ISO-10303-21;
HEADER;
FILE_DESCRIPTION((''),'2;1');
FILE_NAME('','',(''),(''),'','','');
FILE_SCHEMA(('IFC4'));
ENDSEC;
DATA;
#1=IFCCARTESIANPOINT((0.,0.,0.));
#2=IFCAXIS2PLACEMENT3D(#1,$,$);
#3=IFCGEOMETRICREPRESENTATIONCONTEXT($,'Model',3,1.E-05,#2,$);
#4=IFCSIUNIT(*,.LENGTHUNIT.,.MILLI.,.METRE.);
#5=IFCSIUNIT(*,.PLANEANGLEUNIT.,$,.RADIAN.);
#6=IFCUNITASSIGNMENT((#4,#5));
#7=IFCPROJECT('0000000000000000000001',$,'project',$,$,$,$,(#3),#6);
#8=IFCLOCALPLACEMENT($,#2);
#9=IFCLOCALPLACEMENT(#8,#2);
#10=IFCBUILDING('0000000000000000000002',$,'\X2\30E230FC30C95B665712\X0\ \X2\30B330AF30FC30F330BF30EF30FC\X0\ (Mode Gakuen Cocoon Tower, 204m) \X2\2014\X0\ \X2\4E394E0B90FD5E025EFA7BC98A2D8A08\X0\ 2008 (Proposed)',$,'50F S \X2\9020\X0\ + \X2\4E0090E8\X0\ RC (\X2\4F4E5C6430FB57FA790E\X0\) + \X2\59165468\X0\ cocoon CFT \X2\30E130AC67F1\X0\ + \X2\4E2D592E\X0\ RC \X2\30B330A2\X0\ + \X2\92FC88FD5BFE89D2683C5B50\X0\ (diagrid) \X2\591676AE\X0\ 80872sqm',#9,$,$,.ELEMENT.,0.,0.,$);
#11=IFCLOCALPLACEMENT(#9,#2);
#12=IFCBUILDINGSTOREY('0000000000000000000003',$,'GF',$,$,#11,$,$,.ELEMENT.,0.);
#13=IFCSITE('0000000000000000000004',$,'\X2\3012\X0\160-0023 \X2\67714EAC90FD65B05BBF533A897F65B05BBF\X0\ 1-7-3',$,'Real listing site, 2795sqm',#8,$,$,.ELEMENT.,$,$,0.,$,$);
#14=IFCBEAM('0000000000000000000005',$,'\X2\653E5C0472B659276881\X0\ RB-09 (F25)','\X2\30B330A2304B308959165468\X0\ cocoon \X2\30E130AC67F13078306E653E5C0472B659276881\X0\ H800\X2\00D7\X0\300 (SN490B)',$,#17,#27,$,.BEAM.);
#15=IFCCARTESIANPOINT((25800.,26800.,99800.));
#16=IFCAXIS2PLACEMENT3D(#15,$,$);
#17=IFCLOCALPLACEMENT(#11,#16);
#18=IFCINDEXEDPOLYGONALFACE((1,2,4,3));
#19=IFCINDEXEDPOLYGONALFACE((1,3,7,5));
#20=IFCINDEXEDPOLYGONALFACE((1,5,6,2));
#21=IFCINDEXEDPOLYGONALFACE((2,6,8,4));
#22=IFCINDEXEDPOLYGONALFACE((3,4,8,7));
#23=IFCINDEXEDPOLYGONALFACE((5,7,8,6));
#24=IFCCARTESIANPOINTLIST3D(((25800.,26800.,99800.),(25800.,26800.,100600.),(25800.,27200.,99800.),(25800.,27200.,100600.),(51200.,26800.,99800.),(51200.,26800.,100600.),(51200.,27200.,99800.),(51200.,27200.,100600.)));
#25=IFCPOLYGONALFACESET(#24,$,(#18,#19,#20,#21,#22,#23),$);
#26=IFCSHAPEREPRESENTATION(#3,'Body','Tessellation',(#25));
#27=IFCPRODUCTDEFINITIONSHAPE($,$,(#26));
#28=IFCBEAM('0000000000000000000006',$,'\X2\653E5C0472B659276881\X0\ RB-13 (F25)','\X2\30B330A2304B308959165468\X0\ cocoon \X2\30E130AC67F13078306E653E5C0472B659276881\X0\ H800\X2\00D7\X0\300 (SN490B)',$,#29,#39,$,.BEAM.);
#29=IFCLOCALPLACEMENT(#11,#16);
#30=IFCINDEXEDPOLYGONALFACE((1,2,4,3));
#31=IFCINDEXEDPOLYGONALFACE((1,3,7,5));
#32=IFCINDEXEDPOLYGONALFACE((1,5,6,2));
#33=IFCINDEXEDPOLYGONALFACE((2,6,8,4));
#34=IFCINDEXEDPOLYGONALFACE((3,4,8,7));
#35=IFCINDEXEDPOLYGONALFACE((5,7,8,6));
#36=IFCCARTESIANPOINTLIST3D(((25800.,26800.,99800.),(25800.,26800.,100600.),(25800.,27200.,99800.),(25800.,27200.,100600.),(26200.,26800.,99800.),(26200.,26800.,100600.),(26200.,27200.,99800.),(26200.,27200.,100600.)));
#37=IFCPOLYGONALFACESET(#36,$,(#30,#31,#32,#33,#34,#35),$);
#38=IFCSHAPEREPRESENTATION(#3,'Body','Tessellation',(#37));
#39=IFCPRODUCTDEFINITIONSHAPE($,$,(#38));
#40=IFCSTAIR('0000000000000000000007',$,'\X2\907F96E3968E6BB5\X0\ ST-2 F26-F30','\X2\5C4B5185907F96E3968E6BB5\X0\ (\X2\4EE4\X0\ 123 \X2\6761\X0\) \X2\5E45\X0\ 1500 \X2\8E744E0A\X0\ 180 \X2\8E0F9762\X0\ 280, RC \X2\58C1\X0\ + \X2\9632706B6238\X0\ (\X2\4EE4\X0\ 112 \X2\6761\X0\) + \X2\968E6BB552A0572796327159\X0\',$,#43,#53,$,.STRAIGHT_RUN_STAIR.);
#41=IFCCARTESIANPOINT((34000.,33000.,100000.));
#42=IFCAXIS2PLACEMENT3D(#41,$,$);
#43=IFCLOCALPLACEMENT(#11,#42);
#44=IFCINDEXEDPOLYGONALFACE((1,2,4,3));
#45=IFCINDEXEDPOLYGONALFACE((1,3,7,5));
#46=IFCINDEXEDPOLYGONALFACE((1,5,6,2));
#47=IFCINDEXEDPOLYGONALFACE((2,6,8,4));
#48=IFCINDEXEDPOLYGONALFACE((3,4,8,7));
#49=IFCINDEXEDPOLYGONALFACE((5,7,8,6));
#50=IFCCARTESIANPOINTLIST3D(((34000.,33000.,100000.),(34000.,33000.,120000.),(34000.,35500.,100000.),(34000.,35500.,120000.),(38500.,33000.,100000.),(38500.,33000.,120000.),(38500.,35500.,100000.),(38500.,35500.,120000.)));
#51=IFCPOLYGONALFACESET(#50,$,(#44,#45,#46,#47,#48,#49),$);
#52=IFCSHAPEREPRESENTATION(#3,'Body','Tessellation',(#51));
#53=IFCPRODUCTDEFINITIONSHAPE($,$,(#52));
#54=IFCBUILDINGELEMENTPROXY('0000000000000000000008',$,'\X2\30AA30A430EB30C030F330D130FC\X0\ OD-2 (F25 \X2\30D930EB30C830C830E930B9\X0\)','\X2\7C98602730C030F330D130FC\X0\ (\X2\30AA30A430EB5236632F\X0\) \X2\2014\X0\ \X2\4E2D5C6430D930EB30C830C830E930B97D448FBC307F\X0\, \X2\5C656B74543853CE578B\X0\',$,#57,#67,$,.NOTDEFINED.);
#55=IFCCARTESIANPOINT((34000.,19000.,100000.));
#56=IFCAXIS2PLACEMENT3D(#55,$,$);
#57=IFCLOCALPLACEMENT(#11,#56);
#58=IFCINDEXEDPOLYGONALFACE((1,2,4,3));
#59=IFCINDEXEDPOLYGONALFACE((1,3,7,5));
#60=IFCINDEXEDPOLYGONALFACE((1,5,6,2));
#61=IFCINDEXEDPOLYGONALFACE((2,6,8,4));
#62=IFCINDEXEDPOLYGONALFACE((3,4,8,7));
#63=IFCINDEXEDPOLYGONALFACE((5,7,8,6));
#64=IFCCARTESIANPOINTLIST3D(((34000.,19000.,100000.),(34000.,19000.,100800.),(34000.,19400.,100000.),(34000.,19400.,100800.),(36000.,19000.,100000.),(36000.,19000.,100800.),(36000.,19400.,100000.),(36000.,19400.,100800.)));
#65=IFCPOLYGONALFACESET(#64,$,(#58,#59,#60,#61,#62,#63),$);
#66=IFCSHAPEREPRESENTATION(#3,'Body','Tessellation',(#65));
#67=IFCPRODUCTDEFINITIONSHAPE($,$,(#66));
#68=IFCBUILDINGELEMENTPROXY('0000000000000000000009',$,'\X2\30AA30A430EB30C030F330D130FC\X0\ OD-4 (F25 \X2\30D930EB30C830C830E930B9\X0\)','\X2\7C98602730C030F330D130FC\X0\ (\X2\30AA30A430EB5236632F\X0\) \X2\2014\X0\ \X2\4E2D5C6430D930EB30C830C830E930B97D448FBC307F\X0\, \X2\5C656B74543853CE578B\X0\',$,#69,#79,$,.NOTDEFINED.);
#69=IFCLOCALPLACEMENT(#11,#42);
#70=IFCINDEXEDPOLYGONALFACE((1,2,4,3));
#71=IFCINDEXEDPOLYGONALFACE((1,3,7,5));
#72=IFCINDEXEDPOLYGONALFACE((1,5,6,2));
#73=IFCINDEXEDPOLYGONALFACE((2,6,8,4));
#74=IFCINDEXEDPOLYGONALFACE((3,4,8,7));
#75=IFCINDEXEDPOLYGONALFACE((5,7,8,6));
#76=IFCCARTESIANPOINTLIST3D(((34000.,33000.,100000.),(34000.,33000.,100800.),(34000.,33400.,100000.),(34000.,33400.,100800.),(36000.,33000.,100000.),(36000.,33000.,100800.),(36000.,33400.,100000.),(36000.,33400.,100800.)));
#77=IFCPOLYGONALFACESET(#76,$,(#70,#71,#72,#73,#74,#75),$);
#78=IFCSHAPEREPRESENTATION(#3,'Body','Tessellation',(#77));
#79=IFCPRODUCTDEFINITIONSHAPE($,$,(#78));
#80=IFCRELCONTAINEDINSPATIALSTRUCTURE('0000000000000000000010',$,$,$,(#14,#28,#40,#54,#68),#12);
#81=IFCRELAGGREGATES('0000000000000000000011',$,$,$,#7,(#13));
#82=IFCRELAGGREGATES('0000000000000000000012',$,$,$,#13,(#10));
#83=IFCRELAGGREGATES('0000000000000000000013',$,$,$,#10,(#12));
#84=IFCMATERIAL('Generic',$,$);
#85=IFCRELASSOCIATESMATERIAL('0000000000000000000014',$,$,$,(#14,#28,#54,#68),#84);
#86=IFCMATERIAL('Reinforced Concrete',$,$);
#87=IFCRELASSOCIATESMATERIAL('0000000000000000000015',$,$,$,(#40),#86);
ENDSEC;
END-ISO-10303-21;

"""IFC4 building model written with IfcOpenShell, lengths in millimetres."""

from ifc_helpers import new_model, si_unit, frame, frame_2d, origin, place, context, project, spatial, rectangle, extrude, material, element, save


model = new_model("IFC4")

# Units and contexts
model_context = context("Model", 3, precision=1e-05, world=origin())
ifc_project = project(units=[si_unit("LENGTHUNIT", "METRE", prefix="MILLI"), si_unit("PLANEANGLEUNIT", "RADIAN")], contexts=[model_context])

# Site, building, storey
site_placement = place(None, origin())
site = spatial("IfcSite", under=ifc_project, at=site_placement, Name="〒160-0023 東京都新宿区西新宿 1-7-3", ObjectType="Real listing site, 2795sqm", CompositionType="ELEMENT", RefElevation=0.0)
building_placement = place(site_placement, origin())
building = spatial("IfcBuilding", under=site, at=building_placement, Name="モード学園 コクーンタワー (Mode Gakuen Cocoon Tower, 204m) — 丹下都市建築設計 2008 (Proposed)", ObjectType="50F S 造 + 一部 RC (低層・基礎) + 外周 cocoon CFT メガ柱 + 中央 RC コア + 鋼製対角格子 (diagrid) 外皮 80872sqm", CompositionType="ELEMENT", ElevationOfRefHeight=0.0, ElevationOfTerrain=0.0)
storey_placement = place(building_placement, origin())
storey = spatial("IfcBuildingStorey", under=building, at=storey_placement, Name="GF", CompositionType="ELEMENT", Elevation=0.0)

# Shared definitions
ifc_material_1 = material(Name="Generic")

# Beams
beam_1_placement = place(storey_placement, frame((25800.0, 26800.0, 99800.0)))
element("IfcBeam", 1, at=beam_1_placement, inside=storey, material=ifc_material_1, Name="放射状大梁 RB-09 (F25)", Description="コアから外周 cocoon メガ柱への放射状大梁 H800×300 (SN490B)", PredefinedType="BEAM", context=model_context, shape_type="SweptSolid", body=[
    extrude(rectangle(XDim=25400.0, YDim=400.0, at=frame_2d((12700.0, 200.0))), frame((25800.0, 26800.0, 99800.0)), (0.0, 0.0, 1.0), 800.0),
])
beam_2_placement = place(storey_placement, frame((25800.0, 26800.0, 99800.0)))
element("IfcBeam", 2, at=beam_2_placement, inside=storey, material=ifc_material_1, Name="放射状大梁 RB-13 (F25)", Description="コアから外周 cocoon メガ柱への放射状大梁 H800×300 (SN490B)", PredefinedType="BEAM", context=model_context, shape_type="SweptSolid", body=[
    extrude(rectangle(XDim=400.0, YDim=400.0, at=frame_2d((200.0, 200.0))), frame((25800.0, 26800.0, 99800.0)), (0.0, 0.0, 1.0), 800.0),
])

# Stair
ifc_material_2 = material(Name="Reinforced Concrete")
stair_placement = place(storey_placement, frame((34000.0, 33000.0, 100000.0)))
element("IfcStair", 3, at=stair_placement, inside=storey, material=ifc_material_2, Name="避難階段 ST-2 F26-F30", Description="屋内避難階段 (令 123 条) 幅 1500 蹴上 180 踏面 280, RC 壁 + 防火戸 (令 112 条) + 階段加圧防煙", PredefinedType="STRAIGHT_RUN_STAIR", context=model_context, shape_type="SweptSolid", body=[
    extrude(rectangle(XDim=4500.0, YDim=2500.0, at=frame_2d((2250.0, 1250.0))), frame((34000.0, 33000.0, 100000.0)), (0.0, 0.0, 1.0), 20000.0),
])

# Building element proxies
proxy_1_placement = place(storey_placement, frame((34000.0, 19000.0, 100000.0)))
element("IfcBuildingElementProxy", 4, at=proxy_1_placement, inside=storey, material=ifc_material_1, Name="オイルダンパー OD-2 (F25 ベルトトラス)", Description="粘性ダンパー (オイル制振) — 中層ベルトトラス組込み, 履歴吸収型", PredefinedType="NOTDEFINED", context=model_context, shape_type="SweptSolid", body=[
    extrude(rectangle(XDim=2000.0, YDim=400.0, at=frame_2d((1000.0, 200.0))), frame((34000.0, 19000.0, 100000.0)), (0.0, 0.0, 1.0), 800.0),
])
proxy_2_placement = place(storey_placement, frame((34000.0, 33000.0, 100000.0)))
element("IfcBuildingElementProxy", 5, at=proxy_2_placement, inside=storey, material=ifc_material_1, Name="オイルダンパー OD-4 (F25 ベルトトラス)", Description="粘性ダンパー (オイル制振) — 中層ベルトトラス組込み, 履歴吸収型", PredefinedType="NOTDEFINED", context=model_context, shape_type="SweptSolid", body=[
    extrude(rectangle(XDim=2000.0, YDim=400.0, at=frame_2d((1000.0, 200.0))), frame((34000.0, 33000.0, 100000.0)), (0.0, 0.0, 1.0), 800.0),
])

save(model, "model.ifc")
